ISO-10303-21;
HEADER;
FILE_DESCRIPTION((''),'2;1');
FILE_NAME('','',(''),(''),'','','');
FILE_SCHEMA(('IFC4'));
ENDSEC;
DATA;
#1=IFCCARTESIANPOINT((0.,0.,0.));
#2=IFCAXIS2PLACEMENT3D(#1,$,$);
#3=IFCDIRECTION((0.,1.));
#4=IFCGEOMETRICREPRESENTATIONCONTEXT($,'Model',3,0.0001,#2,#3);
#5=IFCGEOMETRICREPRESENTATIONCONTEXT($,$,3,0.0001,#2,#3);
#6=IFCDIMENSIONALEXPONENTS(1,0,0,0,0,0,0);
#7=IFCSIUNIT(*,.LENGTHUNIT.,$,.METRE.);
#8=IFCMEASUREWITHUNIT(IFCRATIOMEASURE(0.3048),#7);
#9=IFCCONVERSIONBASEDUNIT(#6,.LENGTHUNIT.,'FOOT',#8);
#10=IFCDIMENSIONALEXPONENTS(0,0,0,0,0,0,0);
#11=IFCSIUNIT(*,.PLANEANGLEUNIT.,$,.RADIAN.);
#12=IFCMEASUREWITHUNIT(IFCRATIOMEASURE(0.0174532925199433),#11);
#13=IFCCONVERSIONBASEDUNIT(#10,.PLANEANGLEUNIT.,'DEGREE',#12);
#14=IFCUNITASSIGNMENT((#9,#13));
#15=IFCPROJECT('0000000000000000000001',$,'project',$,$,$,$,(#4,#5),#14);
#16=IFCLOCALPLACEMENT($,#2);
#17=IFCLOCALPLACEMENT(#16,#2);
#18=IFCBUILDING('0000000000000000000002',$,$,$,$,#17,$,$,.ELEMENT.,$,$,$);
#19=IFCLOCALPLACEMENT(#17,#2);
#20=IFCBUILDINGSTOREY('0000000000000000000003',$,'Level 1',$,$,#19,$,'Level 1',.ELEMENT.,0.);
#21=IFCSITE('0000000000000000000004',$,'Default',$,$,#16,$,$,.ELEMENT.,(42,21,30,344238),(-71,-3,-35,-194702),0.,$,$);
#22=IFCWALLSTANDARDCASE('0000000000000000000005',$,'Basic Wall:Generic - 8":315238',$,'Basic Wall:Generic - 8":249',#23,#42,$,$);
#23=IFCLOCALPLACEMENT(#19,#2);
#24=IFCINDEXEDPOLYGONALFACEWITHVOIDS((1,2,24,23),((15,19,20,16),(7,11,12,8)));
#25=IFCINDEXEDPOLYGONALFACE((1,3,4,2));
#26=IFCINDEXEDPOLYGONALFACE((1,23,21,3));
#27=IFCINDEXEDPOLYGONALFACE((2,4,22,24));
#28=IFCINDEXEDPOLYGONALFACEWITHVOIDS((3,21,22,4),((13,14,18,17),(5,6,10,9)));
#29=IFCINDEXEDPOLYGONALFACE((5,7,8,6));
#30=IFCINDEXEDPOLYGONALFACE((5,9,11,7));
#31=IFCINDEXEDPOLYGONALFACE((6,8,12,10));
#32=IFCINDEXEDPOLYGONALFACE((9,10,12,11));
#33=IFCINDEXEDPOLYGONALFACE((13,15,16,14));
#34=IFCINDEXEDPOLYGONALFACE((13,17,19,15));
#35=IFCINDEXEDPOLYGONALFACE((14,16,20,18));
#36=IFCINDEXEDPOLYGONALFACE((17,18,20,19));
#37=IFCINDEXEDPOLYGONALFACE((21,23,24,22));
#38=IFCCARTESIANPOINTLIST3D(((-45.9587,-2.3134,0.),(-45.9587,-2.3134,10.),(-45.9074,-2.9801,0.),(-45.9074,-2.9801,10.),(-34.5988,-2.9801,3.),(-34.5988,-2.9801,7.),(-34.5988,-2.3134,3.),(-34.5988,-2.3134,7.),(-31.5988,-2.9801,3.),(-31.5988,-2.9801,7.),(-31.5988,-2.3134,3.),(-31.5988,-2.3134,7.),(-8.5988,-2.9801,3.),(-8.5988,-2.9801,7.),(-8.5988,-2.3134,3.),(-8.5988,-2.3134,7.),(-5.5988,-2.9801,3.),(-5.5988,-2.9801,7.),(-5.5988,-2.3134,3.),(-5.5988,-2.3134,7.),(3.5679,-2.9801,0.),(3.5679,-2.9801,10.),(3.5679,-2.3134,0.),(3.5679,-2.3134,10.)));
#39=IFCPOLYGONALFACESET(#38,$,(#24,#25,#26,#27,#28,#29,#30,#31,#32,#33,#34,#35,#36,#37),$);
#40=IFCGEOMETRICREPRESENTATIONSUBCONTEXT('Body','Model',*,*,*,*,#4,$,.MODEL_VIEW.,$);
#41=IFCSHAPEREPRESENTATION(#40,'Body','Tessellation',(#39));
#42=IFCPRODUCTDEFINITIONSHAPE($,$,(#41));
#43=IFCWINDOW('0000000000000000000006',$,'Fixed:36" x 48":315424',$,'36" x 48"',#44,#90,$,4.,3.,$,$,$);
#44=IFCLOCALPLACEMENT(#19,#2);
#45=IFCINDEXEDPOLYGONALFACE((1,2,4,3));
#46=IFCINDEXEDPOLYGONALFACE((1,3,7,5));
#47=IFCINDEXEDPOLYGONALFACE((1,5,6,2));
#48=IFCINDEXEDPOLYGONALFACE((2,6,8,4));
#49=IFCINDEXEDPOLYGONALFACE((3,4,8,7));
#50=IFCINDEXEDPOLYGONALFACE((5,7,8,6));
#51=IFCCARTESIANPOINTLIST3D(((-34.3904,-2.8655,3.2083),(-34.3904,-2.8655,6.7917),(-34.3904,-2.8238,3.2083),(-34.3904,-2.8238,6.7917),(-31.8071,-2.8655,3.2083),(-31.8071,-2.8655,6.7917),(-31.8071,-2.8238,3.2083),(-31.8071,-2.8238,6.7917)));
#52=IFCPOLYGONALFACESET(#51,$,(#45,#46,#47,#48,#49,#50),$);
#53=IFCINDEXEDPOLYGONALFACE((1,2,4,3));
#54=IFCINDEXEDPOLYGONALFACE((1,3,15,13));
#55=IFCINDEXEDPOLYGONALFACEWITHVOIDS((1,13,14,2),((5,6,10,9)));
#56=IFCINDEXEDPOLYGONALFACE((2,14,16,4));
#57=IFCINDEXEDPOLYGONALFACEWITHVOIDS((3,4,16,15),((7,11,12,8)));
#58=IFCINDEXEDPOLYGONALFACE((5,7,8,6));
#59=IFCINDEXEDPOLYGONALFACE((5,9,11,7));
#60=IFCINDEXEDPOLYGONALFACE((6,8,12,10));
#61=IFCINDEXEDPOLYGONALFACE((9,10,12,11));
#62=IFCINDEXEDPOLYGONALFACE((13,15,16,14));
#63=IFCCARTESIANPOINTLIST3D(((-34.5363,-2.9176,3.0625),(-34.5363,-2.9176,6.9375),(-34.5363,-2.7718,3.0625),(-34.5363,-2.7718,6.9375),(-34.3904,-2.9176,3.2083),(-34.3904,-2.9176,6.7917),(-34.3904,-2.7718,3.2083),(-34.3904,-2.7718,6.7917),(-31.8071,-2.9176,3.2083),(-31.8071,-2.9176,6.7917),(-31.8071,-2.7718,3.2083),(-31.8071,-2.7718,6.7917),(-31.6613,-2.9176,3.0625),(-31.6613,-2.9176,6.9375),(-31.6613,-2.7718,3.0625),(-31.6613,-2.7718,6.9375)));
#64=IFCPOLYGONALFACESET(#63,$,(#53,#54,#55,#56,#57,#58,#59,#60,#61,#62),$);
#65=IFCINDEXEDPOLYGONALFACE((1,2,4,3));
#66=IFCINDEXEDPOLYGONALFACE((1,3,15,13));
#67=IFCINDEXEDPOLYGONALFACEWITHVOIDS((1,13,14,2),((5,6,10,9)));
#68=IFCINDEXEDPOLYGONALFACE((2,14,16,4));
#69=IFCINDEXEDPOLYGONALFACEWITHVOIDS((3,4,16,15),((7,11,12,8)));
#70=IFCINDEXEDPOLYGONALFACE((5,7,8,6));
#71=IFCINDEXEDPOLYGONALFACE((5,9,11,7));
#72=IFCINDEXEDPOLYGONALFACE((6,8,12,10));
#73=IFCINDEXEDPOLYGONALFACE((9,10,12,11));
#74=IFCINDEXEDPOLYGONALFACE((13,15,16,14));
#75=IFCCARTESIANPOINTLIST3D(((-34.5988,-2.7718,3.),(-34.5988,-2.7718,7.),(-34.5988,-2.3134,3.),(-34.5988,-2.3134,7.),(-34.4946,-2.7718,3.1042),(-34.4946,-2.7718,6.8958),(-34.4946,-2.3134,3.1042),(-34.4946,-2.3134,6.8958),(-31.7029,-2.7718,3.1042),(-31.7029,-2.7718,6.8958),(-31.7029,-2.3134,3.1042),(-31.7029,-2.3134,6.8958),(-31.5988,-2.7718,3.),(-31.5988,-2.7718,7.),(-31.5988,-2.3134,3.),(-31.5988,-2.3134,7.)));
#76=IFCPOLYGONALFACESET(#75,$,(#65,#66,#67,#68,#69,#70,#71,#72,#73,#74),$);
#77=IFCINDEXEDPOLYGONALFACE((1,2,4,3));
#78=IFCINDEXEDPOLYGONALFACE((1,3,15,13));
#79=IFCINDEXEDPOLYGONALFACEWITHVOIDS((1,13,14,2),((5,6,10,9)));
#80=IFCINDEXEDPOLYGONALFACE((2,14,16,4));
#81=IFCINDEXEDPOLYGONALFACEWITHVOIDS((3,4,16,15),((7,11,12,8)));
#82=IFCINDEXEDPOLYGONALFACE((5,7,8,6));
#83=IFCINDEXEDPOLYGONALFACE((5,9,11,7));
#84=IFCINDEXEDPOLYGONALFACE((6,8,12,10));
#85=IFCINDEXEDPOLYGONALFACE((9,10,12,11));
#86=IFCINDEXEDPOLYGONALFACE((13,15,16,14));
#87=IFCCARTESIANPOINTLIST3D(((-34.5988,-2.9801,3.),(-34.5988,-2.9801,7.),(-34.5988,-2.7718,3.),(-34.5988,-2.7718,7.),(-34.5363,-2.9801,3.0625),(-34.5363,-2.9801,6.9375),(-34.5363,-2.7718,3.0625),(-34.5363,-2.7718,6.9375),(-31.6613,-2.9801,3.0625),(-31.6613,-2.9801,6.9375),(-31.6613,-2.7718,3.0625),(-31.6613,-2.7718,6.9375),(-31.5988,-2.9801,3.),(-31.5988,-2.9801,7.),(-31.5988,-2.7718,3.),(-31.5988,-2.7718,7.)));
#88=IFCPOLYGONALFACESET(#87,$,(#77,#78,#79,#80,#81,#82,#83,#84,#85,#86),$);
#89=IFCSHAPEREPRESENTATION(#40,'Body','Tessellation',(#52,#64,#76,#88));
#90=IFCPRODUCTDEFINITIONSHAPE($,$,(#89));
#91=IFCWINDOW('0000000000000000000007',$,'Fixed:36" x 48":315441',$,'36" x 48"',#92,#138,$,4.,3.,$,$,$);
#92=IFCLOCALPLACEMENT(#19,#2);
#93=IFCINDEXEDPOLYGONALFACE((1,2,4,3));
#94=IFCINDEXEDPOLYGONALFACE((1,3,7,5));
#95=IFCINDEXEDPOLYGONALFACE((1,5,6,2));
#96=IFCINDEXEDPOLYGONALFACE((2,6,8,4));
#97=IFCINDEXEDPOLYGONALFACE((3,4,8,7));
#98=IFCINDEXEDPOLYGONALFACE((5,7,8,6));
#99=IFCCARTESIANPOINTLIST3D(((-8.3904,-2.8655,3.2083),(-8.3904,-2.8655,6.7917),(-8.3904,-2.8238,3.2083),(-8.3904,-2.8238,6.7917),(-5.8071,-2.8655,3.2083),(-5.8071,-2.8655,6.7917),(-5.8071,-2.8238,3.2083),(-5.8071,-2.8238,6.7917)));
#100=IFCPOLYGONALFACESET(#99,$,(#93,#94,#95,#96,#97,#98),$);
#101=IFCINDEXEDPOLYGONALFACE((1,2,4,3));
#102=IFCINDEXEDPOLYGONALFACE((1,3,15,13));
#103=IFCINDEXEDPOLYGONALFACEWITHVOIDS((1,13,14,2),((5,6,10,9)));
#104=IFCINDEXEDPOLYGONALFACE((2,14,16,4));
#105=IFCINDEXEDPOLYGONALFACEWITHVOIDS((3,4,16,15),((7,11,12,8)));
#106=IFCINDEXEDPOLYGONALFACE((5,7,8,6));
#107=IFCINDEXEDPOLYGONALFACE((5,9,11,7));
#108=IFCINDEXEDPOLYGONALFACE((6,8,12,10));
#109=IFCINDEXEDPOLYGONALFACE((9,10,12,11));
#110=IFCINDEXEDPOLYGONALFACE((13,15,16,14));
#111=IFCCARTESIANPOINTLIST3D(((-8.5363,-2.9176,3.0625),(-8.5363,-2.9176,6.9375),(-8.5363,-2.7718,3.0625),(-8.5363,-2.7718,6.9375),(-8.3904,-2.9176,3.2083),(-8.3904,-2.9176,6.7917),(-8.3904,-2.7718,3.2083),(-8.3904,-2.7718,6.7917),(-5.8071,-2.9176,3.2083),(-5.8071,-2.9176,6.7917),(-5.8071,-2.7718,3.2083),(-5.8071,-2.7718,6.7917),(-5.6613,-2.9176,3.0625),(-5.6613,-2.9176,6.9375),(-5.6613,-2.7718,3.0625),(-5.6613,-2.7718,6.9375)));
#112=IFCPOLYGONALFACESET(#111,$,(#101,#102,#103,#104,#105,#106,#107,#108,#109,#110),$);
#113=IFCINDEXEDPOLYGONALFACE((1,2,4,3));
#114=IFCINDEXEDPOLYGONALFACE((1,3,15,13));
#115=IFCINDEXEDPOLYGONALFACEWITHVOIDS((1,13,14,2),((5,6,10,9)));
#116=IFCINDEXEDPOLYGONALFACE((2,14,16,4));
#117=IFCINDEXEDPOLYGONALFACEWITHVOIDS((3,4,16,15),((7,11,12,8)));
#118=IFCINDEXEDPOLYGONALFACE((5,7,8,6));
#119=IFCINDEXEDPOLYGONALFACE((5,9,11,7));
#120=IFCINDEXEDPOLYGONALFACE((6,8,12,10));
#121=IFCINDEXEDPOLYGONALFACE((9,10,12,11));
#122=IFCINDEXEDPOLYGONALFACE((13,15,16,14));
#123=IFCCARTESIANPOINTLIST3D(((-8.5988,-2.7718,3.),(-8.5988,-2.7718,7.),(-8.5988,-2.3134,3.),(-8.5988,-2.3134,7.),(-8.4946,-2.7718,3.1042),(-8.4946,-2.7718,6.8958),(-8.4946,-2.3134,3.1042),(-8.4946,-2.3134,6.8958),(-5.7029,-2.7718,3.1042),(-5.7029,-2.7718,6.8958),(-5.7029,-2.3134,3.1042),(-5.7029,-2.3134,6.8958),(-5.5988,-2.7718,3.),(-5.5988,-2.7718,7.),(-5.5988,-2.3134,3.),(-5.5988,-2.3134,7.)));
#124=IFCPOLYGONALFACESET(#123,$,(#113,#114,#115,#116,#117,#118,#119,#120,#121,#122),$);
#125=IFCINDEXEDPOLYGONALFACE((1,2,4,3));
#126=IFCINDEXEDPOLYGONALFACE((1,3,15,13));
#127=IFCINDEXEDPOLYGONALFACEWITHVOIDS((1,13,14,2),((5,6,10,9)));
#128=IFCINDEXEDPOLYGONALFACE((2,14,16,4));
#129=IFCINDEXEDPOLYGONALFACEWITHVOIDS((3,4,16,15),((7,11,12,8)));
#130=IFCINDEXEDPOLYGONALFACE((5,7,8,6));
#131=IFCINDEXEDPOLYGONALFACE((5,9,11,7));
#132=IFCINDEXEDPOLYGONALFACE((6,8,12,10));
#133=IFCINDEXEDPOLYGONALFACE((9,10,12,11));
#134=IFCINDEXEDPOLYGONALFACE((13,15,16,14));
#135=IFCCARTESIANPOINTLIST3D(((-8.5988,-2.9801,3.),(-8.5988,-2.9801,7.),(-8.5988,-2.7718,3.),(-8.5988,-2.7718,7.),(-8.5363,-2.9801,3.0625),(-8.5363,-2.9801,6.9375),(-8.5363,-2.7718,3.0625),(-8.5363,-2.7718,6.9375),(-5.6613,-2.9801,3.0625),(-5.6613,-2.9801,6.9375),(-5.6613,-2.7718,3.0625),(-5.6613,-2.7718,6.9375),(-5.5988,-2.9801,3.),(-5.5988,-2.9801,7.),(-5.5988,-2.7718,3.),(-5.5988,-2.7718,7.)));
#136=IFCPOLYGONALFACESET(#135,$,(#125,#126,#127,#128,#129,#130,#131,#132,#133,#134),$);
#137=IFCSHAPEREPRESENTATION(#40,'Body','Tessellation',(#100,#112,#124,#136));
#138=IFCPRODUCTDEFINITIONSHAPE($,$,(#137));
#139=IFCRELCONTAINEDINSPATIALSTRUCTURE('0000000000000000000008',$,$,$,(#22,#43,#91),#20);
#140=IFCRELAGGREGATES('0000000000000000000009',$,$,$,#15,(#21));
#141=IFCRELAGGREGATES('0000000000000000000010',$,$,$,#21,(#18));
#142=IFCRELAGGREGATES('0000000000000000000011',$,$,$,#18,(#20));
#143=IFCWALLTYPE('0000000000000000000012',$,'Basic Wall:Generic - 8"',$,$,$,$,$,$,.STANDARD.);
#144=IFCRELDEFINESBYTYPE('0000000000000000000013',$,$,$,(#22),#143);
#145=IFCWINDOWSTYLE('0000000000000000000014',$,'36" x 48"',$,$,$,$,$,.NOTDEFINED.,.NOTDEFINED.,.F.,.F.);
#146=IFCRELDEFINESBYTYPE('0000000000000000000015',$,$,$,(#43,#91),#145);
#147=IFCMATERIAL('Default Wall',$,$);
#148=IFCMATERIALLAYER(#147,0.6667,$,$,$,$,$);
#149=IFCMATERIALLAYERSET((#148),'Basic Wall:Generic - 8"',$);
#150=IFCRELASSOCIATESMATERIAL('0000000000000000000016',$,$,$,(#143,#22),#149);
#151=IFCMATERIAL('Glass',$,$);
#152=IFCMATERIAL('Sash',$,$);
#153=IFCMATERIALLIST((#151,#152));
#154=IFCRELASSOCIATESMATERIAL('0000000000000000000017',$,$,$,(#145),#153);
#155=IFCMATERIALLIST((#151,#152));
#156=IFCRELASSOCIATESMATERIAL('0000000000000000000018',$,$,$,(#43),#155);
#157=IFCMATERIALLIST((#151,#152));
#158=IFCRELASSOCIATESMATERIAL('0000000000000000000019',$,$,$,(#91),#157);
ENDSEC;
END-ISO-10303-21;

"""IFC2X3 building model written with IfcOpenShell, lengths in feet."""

from ifc_helpers import new_model, entity, si_unit, converted_unit, direction, frame, frame_2d, origin, place, context, subcontext, project, spatial, polyline, rectangle, outline, extrude, clip, bounded_halfspace, source, transform, mapped, material, material_list, layer, layer_set, layer_usage, type_object, type_shapes, element, fill, save


model = new_model("IFC2X3")

# Units and contexts
model_context = context("Model", 3, precision=0.0001, world=origin(), true_north=direction((0.0, 1.0)))
context_of_model = context(None, 3, precision=0.0001, world=origin(), true_north=direction((0.0, 1.0)))
body_context = subcontext(model_context, "Body", "Model", "MODEL_VIEW")
ifc_project = project(units=[converted_unit("LENGTHUNIT", "FOOT", entity("IfcRatioMeasure", 0.3048), si_unit("LENGTHUNIT", "METRE"), dimensions=[1, 0, 0, 0, 0, 0, 0]), converted_unit("PLANEANGLEUNIT", "DEGREE", entity("IfcRatioMeasure", 0.0174532925199433), si_unit("PLANEANGLEUNIT", "RADIAN"), dimensions=[0, 0, 0, 0, 0, 0, 0])], contexts=[model_context, context_of_model])

# Site, building, storey
site_placement = place(None, origin())
site = spatial("IfcSite", under=ifc_project, at=site_placement, Name="Default", CompositionType="ELEMENT", RefLatitude=(42, 21, 30, 344238), RefLongitude=(-71, -3, -35, -194702), RefElevation=0.0)
building_placement = place(site_placement, origin())
building = spatial("IfcBuilding", under=site, at=building_placement, CompositionType="ELEMENT")
storey_placement = place(building_placement, origin())
storey = spatial("IfcBuildingStorey", under=building, at=storey_placement, Name="Level 1", LongName="Level 1", CompositionType="ELEMENT", Elevation=0.0)

# Shared definitions
ifc_material_1 = material(Name="Default Wall")
ifc_layer_1 = layer(ifc_material_1, 0.6667)
ifc_layer_set_1 = layer_set([ifc_layer_1], Name="Basic Wall:Generic - 8\"")
wall_type = type_object("IfcWallType", Name="Basic Wall:Generic - 8\"", PredefinedType="STANDARD", material=ifc_layer_set_1)
ifc_material_2 = material(Name="Glass")
ifc_material_3 = material(Name="Sash")
ifc_material_list_1 = material_list([ifc_material_2, ifc_material_3])
window_style = type_object("IfcWindowStyle", Name="36\" x 48\"", ConstructionType="NOTDEFINED", OperationType="NOTDEFINED", ParameterTakesPrecedence=False, Sizeable=False, material=ifc_material_list_1)
shared_shape_1 = source(origin(), body_context, "Body", "SweptSolid", [
    extrude(rectangle(XDim=0.0417, YDim=2.5833, at=frame_2d((0.0, 0.0), x_axis=(1.0, 0.0))), frame((1.5, 0.5312, 0.2083), z_axis=(0.0, 0.0, 1.0), x_axis=(0.0, 1.0, 0.0)), (0.0, 0.0, 1.0), 3.5833),
    extrude(outline(polyline([(-1.4375, -1.9375), (1.4375, -1.9375), (1.4375, 1.9375), (-1.4375, 1.9375), (-1.4375, -1.9375)]), holes=[polyline([(-1.2917, -1.7917), (-1.2917, 1.7917), (1.2917, 1.7917), (1.2917, -1.7917), (-1.2917, -1.7917)])]), frame((1.5, 0.4583, 2.0), z_axis=(0.0, 1.0, 0.0), x_axis=(1.0, 0.0, 0.0)), (0.0, 0.0, 1.0), 0.1458),
    extrude(outline(polyline([(-1.5, -2.0), (1.5, -2.0), (1.5, 2.0), (-1.5, 2.0), (-1.5, -2.0)]), holes=[polyline([(-1.3958, -1.8958), (-1.3958, 1.8958), (1.3958, 1.8958), (1.3958, -1.8958), (-1.3958, -1.8958)])]), frame((1.5, 0.0, 2.0), z_axis=(0.0, 1.0, 0.0), x_axis=(1.0, 0.0, 0.0)), (0.0, 0.0, 1.0), 0.4583),
    extrude(outline(polyline([(-2.0, -1.5), (2.0, -1.5), (2.0, 1.5), (-2.0, 1.5), (-2.0, -1.5)]), holes=[polyline([(-1.9375, -1.4375), (-1.9375, 1.4375), (1.9375, 1.4375), (1.9375, -1.4375), (-1.9375, -1.4375)])]), frame((1.5, 0.4583, 2.0), z_axis=(0.0, 1.0, 0.0), x_axis=(0.0, 0.0, -1.0)), (0.0, 0.0, 1.0), 0.2083),
])
type_shapes(window_style, [shared_shape_1])

# Wall, openings, windows
ifc_layer_usage_1 = layer_usage(ifc_layer_set_1, "AXIS2", "NEGATIVE", 0.3333)
wall_1_placement = place(storey_placement, frame((3.5679, -2.6468, 0.0), z_axis=(0.0, 0.0, 1.0), x_axis=(-1.0, 0.0, 0.0)))
wall_1 = element("IfcWallStandardCase", 1, at=wall_1_placement, inside=storey, type_object=wall_type, material=ifc_layer_usage_1, Name="Basic Wall:Generic - 8\":315238", ObjectType="Basic Wall:Generic - 8\":249", context=body_context, shape_type="Clipping", body=[
    clip(extrude(outline(polyline([(49.5266, -0.3333), (49.4753, 0.3333), (0.0, 0.3333), (0.0, -0.3333), (23.108, -0.3333), (23.7766, -0.3333), (48.858, -0.3333), (49.5266, -0.3333)])), origin(), (0.0, 0.0, 1.0), 10.0), bounded_halfspace(frame((0.0, -0.3333, 10.0), z_axis=(0.0, 0.0, 1.0), x_axis=(-1.0, 0.0, 0.0)), False, frame((0.0, -0.3333, 10.0)), polyline([(0.0, 0.0), (23.108, 0.0), (23.7766, 0.0), (48.858, 0.0), (49.5266, 0.0), (49.4753, 0.6667), (0.0, 0.6667), (0.0, 0.0)]))),
])
opening_1_placement = place(wall_1_placement, frame((35.1667, -0.3333, 3.0)))
opening_1 = element("IfcOpeningElement", 2, at=opening_1_placement, cuts=wall_1, ObjectType="Opening", context=body_context, shape_type="SweptSolid", body=[
    extrude(rectangle(XDim=4.0, YDim=3.0, at=frame_2d((2.0, 1.5), x_axis=(-1.0, 0.0))), frame((0.0, 0.0, 0.0), z_axis=(0.0, 1.0, 0.0), x_axis=(0.0, 0.0, 1.0)), (0.0, 0.0, 1.0), 0.6667),
])
opening_2_placement = place(wall_1_placement, frame((9.1667, -0.3333, 3.0)))
opening_2 = element("IfcOpeningElement", 3, at=opening_2_placement, cuts=wall_1, ObjectType="Opening", context=body_context, shape_type="SweptSolid", body=[
    extrude(rectangle(XDim=4.0, YDim=3.0, at=frame_2d((2.0, 1.5), x_axis=(-1.0, 0.0))), frame((0.0, 0.0, 0.0), z_axis=(0.0, 1.0, 0.0), x_axis=(0.0, 0.0, 1.0)), (0.0, 0.0, 1.0), 0.6667),
])
ifc_material_list_2 = material_list([ifc_material_2, ifc_material_3])
window_1_placement = place(opening_1_placement, origin())
window_1 = element("IfcWindow", 4, at=window_1_placement, inside=storey, type_object=window_style, material=ifc_material_list_2, Name="Fixed:36\" x 48\":315424", ObjectType="36\" x 48\"", OverallHeight=4.0, OverallWidth=3.0, context=body_context, shape_type="MappedRepresentation", body=[
    mapped(shared_shape_1, transform((0.0, 0.0, 0.0), scale=1.0)),
])
fill(opening_1, window_1)
ifc_material_list_3 = material_list([ifc_material_2, ifc_material_3])
window_2_placement = place(opening_2_placement, origin())
window_2 = element("IfcWindow", 5, at=window_2_placement, inside=storey, type_object=window_style, material=ifc_material_list_3, Name="Fixed:36\" x 48\":315441", ObjectType="36\" x 48\"", OverallHeight=4.0, OverallWidth=3.0, context=body_context, shape_type="MappedRepresentation", body=[
    mapped(shared_shape_1, transform((0.0, 0.0, 0.0), scale=1.0)),
])
fill(opening_2, window_2)

save(model, "model.ifc")
